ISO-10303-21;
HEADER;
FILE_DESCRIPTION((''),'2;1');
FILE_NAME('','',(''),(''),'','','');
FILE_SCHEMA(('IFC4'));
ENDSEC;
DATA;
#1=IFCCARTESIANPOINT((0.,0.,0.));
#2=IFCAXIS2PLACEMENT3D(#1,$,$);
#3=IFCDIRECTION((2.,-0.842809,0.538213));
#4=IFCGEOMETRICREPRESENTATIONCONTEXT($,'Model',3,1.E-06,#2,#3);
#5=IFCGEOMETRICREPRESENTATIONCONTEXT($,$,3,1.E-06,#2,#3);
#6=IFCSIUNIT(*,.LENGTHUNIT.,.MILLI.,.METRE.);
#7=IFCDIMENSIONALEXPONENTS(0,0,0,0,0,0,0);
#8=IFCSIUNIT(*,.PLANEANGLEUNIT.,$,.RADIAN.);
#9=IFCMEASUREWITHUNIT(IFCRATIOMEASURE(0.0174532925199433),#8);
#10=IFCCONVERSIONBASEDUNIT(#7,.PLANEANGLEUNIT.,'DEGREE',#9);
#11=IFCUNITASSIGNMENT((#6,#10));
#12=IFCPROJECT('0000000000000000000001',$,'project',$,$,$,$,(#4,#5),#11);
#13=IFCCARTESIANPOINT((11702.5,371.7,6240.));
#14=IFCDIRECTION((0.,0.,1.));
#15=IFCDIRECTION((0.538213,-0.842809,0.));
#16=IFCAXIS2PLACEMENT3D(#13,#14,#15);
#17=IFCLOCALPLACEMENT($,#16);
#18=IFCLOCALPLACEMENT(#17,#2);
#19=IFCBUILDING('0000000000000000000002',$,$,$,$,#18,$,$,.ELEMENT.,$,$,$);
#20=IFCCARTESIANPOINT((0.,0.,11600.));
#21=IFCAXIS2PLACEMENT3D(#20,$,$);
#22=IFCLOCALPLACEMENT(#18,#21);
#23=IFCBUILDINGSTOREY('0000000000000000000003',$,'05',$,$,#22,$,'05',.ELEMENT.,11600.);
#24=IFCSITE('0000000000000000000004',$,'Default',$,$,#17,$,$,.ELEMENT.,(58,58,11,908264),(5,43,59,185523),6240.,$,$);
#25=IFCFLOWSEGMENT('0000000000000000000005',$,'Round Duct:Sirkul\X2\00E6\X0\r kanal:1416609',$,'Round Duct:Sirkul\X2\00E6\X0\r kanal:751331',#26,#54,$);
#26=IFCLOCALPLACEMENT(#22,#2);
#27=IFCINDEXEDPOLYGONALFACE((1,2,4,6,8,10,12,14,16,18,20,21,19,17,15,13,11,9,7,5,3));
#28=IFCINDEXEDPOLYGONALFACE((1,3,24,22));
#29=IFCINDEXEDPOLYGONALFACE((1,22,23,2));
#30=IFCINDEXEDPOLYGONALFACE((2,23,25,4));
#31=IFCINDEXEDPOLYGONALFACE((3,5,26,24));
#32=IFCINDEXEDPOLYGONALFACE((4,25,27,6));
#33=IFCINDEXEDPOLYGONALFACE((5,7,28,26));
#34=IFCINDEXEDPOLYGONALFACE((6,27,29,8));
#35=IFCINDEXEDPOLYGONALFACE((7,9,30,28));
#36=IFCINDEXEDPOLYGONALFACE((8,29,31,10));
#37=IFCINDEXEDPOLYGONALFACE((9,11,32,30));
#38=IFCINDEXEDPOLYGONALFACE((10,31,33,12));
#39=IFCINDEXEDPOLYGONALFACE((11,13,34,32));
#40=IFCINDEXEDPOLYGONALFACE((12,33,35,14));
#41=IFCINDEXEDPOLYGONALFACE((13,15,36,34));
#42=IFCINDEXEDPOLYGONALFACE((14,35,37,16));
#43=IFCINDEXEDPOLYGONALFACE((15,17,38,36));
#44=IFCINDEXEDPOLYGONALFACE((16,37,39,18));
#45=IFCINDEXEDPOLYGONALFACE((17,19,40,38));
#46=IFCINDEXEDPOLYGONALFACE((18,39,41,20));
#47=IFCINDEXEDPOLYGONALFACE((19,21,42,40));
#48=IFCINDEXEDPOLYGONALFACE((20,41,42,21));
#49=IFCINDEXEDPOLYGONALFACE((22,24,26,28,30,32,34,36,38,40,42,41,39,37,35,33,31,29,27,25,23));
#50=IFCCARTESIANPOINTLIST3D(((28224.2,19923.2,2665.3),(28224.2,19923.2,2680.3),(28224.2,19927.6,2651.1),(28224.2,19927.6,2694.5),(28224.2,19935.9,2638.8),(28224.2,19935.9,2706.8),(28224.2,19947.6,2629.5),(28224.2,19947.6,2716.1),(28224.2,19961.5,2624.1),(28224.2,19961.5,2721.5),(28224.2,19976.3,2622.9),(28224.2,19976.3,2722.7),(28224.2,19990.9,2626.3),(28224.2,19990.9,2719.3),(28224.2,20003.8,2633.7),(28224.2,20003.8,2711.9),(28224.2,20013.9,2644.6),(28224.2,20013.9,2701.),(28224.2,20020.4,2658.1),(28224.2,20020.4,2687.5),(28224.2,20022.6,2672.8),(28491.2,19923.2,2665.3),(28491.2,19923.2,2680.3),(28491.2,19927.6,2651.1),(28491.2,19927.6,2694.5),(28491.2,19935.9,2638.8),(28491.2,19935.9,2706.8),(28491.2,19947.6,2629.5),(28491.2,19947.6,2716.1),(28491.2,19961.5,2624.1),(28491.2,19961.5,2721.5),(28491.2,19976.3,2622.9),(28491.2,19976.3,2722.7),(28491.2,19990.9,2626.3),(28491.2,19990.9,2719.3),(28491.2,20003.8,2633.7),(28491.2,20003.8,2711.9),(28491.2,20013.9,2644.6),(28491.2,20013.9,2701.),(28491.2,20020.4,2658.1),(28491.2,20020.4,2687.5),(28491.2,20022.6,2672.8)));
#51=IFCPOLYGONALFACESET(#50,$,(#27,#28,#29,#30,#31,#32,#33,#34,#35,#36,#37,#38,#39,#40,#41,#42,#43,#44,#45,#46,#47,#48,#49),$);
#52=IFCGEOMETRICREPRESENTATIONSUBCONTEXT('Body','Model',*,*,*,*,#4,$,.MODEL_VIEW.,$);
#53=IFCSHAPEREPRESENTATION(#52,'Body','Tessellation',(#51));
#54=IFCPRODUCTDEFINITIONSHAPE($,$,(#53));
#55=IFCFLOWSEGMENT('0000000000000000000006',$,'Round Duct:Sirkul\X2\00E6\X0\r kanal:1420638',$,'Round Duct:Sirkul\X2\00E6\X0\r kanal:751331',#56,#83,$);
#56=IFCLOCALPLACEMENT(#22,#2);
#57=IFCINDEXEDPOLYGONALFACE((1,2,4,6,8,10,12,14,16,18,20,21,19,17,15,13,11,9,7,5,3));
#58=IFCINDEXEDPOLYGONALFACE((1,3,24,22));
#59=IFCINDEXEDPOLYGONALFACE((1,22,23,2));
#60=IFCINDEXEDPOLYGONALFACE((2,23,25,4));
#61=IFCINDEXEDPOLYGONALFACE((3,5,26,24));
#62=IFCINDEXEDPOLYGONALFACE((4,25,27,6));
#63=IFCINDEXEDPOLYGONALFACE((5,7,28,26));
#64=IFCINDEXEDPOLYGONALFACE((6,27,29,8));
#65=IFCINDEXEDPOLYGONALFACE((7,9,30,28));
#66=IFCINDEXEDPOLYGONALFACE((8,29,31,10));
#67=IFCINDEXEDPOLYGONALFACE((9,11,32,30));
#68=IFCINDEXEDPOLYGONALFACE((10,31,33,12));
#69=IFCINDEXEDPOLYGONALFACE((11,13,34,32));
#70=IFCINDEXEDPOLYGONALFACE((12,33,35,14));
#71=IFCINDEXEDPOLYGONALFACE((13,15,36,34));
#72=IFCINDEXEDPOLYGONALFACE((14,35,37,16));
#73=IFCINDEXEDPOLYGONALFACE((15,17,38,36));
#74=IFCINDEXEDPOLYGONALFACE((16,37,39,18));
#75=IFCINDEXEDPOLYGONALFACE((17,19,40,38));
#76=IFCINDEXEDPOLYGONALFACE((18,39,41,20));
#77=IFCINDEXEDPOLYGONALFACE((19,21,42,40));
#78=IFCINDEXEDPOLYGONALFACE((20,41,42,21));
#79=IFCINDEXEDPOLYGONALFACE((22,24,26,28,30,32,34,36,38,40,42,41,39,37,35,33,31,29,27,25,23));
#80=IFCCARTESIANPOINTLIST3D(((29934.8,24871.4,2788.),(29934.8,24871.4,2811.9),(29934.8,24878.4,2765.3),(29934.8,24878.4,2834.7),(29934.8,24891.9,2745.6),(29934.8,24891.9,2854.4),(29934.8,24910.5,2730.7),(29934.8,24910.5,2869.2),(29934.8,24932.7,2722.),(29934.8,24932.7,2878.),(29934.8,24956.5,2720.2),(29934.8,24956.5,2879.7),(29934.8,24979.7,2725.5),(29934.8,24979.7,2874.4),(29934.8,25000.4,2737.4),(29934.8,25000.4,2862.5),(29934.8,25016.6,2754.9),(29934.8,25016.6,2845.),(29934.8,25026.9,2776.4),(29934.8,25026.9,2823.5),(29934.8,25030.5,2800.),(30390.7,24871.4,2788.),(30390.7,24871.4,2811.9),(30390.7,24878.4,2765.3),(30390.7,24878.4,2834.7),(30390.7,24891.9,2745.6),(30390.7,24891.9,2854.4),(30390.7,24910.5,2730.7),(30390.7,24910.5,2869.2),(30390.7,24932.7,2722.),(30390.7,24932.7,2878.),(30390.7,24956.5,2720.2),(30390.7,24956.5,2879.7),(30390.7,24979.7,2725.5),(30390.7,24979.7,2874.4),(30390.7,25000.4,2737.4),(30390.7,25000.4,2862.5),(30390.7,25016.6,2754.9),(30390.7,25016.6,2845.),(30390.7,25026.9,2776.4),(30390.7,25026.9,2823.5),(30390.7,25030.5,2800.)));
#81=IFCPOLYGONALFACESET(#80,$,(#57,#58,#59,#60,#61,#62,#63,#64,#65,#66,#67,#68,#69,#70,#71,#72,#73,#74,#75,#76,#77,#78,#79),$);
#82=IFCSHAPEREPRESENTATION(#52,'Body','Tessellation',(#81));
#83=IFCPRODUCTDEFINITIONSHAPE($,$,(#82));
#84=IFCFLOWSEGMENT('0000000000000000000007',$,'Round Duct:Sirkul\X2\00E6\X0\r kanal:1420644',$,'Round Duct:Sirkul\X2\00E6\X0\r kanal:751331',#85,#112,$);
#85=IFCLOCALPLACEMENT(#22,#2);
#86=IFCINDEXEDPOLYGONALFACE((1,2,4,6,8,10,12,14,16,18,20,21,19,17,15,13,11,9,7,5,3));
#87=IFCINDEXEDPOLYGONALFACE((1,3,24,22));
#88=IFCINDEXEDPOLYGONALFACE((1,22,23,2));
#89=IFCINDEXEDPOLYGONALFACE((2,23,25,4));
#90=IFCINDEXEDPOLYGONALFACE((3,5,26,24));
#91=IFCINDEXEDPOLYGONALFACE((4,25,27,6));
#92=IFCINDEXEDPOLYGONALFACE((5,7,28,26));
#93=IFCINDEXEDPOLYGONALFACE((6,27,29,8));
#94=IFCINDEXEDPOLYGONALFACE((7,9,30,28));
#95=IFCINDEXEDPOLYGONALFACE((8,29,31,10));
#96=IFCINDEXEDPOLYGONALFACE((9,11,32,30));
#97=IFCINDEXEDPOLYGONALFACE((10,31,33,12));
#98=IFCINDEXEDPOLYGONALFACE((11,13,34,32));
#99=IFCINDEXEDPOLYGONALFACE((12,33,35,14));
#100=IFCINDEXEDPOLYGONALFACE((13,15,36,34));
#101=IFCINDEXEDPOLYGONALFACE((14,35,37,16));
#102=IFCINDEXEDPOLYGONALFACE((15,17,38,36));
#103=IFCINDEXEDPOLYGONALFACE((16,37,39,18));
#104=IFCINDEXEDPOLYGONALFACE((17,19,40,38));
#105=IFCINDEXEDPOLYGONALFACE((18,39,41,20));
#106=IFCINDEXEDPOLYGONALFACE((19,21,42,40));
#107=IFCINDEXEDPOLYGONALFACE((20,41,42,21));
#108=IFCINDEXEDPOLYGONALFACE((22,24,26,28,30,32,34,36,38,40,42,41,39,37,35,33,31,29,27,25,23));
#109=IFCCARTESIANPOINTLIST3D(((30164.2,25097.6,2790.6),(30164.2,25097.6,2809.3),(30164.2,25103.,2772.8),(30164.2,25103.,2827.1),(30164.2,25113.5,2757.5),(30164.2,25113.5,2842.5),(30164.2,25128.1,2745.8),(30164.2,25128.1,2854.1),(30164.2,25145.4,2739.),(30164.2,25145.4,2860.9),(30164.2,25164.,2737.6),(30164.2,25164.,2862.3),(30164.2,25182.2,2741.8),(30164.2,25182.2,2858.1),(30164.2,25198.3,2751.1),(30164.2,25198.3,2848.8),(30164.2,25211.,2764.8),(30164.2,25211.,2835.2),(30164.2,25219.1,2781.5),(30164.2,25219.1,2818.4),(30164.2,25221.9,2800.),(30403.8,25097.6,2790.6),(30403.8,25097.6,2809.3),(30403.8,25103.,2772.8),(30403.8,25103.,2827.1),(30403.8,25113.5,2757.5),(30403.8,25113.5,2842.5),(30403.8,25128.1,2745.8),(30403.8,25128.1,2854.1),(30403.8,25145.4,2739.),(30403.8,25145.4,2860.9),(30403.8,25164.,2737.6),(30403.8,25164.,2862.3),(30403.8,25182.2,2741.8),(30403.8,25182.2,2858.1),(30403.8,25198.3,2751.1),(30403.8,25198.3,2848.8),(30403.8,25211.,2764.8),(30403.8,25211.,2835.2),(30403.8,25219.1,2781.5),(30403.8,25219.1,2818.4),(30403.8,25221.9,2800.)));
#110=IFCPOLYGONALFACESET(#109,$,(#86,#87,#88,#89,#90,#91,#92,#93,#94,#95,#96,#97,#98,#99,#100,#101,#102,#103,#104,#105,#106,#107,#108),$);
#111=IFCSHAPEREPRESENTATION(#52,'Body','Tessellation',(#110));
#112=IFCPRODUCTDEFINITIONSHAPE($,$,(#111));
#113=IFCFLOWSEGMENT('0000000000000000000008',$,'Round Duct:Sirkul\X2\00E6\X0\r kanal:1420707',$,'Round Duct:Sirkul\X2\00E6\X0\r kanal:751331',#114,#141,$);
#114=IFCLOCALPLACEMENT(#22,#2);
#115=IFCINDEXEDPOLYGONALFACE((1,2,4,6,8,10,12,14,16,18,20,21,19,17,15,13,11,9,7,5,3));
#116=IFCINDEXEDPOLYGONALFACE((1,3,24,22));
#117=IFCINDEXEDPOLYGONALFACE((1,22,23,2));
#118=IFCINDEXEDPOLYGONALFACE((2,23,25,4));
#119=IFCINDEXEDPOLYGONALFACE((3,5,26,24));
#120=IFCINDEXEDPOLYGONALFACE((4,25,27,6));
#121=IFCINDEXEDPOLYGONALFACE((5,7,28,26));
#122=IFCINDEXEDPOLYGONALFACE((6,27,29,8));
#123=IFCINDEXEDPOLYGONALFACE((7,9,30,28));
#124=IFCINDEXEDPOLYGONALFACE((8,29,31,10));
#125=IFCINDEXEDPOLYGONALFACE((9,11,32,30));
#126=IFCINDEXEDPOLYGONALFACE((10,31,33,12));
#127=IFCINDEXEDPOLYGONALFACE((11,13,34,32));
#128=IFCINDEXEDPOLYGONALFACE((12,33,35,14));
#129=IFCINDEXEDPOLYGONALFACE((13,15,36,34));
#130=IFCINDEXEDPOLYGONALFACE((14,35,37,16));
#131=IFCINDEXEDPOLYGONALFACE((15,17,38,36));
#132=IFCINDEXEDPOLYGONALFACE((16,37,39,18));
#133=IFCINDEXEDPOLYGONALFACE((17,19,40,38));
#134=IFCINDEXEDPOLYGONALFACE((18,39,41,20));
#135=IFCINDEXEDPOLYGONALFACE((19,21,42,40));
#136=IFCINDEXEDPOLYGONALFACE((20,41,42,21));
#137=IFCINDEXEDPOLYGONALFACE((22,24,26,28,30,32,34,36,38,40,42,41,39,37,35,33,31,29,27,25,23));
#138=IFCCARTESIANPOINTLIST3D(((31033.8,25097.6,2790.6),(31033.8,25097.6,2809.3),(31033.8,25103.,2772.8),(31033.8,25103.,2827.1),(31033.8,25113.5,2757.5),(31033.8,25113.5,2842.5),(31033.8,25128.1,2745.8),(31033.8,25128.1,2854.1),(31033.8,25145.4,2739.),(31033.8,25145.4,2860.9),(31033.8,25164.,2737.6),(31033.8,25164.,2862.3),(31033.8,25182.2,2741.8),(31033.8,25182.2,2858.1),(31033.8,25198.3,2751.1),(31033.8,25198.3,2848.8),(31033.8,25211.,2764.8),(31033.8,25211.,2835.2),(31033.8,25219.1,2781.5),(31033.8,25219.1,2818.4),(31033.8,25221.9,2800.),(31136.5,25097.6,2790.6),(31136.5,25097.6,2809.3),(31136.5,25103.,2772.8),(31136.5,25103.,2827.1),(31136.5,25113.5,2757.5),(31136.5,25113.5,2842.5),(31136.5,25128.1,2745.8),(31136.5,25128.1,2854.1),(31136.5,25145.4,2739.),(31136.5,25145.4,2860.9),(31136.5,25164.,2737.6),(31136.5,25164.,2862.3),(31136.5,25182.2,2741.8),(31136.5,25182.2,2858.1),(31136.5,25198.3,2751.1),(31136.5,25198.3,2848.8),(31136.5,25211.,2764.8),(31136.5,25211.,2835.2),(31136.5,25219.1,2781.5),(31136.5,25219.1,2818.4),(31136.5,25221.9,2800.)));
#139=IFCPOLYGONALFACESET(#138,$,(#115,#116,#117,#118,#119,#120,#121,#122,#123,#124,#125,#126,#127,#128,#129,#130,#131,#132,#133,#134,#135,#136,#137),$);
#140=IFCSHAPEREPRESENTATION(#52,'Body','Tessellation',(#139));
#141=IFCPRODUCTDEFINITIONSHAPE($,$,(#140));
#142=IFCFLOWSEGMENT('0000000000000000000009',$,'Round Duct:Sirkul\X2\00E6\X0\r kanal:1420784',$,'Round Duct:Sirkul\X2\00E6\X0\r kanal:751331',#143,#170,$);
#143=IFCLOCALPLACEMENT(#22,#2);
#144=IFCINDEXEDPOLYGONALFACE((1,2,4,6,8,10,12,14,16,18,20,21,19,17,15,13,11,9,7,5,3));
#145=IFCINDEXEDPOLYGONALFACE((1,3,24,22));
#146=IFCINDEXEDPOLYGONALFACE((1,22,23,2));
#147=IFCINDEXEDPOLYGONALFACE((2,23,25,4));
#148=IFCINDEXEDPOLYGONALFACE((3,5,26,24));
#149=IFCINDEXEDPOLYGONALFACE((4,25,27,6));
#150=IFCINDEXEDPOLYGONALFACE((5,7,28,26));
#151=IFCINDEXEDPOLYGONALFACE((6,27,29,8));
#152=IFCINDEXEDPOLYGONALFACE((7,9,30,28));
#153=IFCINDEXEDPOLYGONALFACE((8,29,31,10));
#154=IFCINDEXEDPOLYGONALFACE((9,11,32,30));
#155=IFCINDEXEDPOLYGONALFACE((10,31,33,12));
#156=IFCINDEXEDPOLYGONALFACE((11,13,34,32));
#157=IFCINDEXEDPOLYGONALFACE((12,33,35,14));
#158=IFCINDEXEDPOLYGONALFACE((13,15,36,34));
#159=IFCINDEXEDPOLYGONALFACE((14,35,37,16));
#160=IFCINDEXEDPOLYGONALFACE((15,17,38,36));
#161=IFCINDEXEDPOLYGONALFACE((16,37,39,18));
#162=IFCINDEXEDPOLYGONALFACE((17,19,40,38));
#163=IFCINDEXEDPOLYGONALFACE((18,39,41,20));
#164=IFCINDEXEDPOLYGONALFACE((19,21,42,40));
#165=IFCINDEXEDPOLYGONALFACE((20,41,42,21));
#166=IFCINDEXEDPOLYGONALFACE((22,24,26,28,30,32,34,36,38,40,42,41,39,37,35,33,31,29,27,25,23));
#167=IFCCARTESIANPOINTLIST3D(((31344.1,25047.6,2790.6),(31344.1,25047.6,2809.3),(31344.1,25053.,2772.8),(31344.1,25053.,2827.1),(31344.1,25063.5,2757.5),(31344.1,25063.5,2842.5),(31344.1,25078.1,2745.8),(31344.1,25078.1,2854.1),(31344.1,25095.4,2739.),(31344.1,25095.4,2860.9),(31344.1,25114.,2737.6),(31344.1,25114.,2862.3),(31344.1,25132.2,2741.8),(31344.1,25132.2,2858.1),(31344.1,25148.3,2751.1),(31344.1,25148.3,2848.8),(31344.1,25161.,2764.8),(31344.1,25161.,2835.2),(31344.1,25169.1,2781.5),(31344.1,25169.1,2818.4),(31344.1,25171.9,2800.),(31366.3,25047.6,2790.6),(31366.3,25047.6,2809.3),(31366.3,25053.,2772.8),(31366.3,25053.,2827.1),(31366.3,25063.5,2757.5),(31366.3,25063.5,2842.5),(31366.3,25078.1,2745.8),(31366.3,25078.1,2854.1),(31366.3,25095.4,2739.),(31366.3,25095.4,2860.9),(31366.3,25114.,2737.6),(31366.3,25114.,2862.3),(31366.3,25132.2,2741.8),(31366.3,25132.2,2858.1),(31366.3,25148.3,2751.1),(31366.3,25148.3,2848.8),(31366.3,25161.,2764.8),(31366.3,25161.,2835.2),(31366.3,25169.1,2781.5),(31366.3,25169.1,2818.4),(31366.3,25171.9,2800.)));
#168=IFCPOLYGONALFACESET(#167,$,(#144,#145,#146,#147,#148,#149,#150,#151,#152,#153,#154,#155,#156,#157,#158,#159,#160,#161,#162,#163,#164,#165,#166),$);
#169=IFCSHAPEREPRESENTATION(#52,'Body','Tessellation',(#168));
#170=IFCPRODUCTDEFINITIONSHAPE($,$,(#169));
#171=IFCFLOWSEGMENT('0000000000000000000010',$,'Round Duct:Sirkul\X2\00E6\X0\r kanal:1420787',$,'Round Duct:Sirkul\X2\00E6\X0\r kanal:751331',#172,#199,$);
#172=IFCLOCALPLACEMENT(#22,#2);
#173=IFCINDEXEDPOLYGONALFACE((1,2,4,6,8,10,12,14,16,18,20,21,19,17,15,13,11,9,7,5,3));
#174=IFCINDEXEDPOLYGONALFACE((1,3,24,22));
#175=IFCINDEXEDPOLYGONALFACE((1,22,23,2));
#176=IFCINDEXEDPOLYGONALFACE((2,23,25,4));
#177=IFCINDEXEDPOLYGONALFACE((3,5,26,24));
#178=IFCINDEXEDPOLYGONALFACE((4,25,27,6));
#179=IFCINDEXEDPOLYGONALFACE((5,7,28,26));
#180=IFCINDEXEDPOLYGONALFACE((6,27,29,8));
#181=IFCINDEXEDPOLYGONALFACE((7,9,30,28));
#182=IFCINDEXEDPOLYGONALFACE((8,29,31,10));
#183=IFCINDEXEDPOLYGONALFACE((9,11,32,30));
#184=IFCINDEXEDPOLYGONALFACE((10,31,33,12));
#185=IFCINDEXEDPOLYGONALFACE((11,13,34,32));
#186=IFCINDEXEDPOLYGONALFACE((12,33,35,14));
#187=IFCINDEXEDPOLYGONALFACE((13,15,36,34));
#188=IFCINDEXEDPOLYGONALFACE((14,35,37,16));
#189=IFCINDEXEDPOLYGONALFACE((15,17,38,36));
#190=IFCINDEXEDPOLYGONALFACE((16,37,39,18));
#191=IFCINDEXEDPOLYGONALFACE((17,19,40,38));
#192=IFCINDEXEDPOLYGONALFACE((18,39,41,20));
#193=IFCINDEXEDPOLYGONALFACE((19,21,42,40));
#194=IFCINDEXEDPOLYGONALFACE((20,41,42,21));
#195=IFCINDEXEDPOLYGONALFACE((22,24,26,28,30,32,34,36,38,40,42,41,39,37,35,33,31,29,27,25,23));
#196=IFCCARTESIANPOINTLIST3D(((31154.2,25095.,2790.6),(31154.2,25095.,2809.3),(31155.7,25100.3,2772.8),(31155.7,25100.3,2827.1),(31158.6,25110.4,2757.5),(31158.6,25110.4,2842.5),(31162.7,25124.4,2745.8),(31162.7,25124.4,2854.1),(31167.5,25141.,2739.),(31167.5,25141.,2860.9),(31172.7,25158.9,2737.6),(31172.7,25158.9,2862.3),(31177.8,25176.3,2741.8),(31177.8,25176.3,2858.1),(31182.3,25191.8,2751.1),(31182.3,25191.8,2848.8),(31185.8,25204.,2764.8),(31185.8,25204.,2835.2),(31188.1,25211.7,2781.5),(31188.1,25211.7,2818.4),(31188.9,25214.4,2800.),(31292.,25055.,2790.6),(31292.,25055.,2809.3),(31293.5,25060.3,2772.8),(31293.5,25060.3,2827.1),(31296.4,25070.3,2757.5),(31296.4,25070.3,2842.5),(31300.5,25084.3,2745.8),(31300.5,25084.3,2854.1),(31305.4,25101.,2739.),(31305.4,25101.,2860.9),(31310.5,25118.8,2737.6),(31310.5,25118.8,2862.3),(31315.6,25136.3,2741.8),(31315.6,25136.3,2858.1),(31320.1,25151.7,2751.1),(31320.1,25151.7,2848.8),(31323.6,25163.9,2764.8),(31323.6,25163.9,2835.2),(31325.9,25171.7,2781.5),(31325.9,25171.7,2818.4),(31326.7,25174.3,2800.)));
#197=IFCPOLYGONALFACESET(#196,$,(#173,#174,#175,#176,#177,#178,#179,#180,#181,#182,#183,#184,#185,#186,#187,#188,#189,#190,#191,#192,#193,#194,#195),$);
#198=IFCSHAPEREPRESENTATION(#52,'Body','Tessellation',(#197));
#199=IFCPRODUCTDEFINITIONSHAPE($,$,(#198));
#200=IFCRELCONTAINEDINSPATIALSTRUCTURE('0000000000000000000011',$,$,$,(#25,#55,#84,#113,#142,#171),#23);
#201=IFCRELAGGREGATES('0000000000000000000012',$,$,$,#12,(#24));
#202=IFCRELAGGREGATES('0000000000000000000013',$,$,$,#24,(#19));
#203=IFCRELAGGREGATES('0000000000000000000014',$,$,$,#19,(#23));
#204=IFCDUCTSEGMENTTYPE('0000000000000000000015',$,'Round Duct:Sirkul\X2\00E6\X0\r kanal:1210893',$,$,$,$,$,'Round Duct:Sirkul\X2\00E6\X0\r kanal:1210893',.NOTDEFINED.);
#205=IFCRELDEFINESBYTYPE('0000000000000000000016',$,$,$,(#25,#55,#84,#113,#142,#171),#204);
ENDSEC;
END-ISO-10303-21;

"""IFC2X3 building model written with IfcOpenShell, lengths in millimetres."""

from ifc_helpers import new_model, entity, si_unit, converted_unit, direction, frame, frame_2d, origin, origin_2d_with_axis, place, context, subcontext, project, spatial, circle, extrude, type_object, element, save


model = new_model("IFC2X3")

# Units and contexts
model_context = context("Model", 3, precision=1e-06, world=origin(), true_north=direction((2.0, -0.842809, 0.538213)))
context_of_model = context(None, 3, precision=1e-06, world=origin(), true_north=direction((2.0, -0.842809, 0.538213)))
body_context = subcontext(model_context, "Body", "Model", "MODEL_VIEW")
ifc_project = project(units=[si_unit("LENGTHUNIT", "METRE", prefix="MILLI"), converted_unit("PLANEANGLEUNIT", "DEGREE", entity("IfcRatioMeasure", 0.0174532925199433), si_unit("PLANEANGLEUNIT", "RADIAN"), dimensions=[0, 0, 0, 0, 0, 0, 0])], contexts=[model_context, context_of_model])

# Site, building, storey
site_placement = place(None, frame((11702.5, 371.7, 6240.0), z_axis=(0.0, 0.0, 1.0), x_axis=(0.538213, -0.842809, 0.0)))
site = spatial("IfcSite", under=ifc_project, at=site_placement, Name="Default", CompositionType="ELEMENT", RefLatitude=(58, 58, 11, 908264), RefLongitude=(5, 43, 59, 185523), RefElevation=6240.0)
building_placement = place(site_placement, origin())
building = spatial("IfcBuilding", under=site, at=building_placement, CompositionType="ELEMENT")
storey_placement = place(building_placement, frame((0.0, 0.0, 11600.0)))
storey = spatial("IfcBuildingStorey", under=building, at=storey_placement, Name="05", LongName="05", CompositionType="ELEMENT", Elevation=11600.0)

# Flow segments
duct_segment_type = type_object("IfcDuctSegmentType", Name="Round Duct:Sirkulær kanal:1210893", ElementType="Round Duct:Sirkulær kanal:1210893", PredefinedType="NOTDEFINED")
flow_segment_1_placement = place(storey_placement, origin())
element("IfcFlowSegment", 1, at=flow_segment_1_placement, inside=storey, type_object=duct_segment_type, Name="Round Duct:Sirkulær kanal:1416609", ObjectType="Round Duct:Sirkulær kanal:751331", context=body_context, shape_type="SweptSolid", body=[
    extrude(circle(Radius=50.0, at=frame_2d((0.0, 0.0), x_axis=(1.0, 0.0))), frame((28224.2, 19972.6, 2672.8), z_axis=(1.0, 0.0, 0.0), x_axis=(0.0, 1.0, 0.0)), (0.0, 0.0, 1.0), 267.0),
])
flow_segment_2_placement = place(storey_placement, origin())
element("IfcFlowSegment", 2, at=flow_segment_2_placement, inside=storey, type_object=duct_segment_type, Name="Round Duct:Sirkulær kanal:1420638", ObjectType="Round Duct:Sirkulær kanal:751331", context=body_context, shape_type="SweptSolid", body=[
    extrude(circle(Radius=80.0, at=frame_2d((0.0, 0.0), x_axis=(1.0, 0.0))), frame((29934.8, 24950.5, 2800.0), z_axis=(1.0, 0.0, 0.0), x_axis=(0.0, 1.0, 0.0)), (0.0, 0.0, 1.0), 455.9),
])
flow_segment_3_placement = place(storey_placement, origin())
element("IfcFlowSegment", 3, at=flow_segment_3_placement, inside=storey, type_object=duct_segment_type, Name="Round Duct:Sirkulær kanal:1420644", ObjectType="Round Duct:Sirkulær kanal:751331", context=body_context, shape_type="SweptSolid", body=[
    extrude(circle(Radius=62.5, at=frame_2d((0.0, 0.0), x_axis=(1.0, 0.0))), frame((30164.2, 25159.4, 2800.0), z_axis=(1.0, 0.0, 0.0), x_axis=(0.0, 1.0, 0.0)), (0.0, 0.0, 1.0), 239.6),
])
flow_segment_4_placement = place(storey_placement, origin())
element("IfcFlowSegment", 4, at=flow_segment_4_placement, inside=storey, type_object=duct_segment_type, Name="Round Duct:Sirkulær kanal:1420707", ObjectType="Round Duct:Sirkulær kanal:751331", context=body_context, shape_type="SweptSolid", body=[
    extrude(circle(Radius=62.5, at=frame_2d((0.0, 0.0), x_axis=(1.0, 0.0))), frame((31033.8, 25159.4, 2800.0), z_axis=(1.0, 0.0, 0.0), x_axis=(0.0, 1.0, 0.0)), (0.0, 0.0, 1.0), 102.7),
])
flow_segment_5_placement = place(storey_placement, origin())
element("IfcFlowSegment", 5, at=flow_segment_5_placement, inside=storey, type_object=duct_segment_type, Name="Round Duct:Sirkulær kanal:1420784", ObjectType="Round Duct:Sirkulær kanal:751331", context=body_context, shape_type="SweptSolid", body=[
    extrude(circle(Radius=62.5, at=origin_2d_with_axis()), frame((31344.1, 25109.4, 2800.0), z_axis=(1.0, 0.0, 0.0), x_axis=(0.0, 1.0, 0.0)), (0.0, 0.0, 1.0), 22.2),
])
flow_segment_6_placement = place(storey_placement, origin())
element("IfcFlowSegment", 6, at=flow_segment_6_placement, inside=storey, type_object=duct_segment_type, Name="Round Duct:Sirkulær kanal:1420787", ObjectType="Round Duct:Sirkulær kanal:751331", context=body_context, shape_type="SweptSolid", body=[
    extrude(circle(Radius=62.5, at=origin_2d_with_axis()), frame((31309.2, 25114.3, 2800.0), z_axis=(-0.96025, 0.279142, 0.0), x_axis=(0.279142, 0.96025, 0.0)), (0.0, 0.0, 1.0), 143.5),
])

save(model, "model.ifc")
